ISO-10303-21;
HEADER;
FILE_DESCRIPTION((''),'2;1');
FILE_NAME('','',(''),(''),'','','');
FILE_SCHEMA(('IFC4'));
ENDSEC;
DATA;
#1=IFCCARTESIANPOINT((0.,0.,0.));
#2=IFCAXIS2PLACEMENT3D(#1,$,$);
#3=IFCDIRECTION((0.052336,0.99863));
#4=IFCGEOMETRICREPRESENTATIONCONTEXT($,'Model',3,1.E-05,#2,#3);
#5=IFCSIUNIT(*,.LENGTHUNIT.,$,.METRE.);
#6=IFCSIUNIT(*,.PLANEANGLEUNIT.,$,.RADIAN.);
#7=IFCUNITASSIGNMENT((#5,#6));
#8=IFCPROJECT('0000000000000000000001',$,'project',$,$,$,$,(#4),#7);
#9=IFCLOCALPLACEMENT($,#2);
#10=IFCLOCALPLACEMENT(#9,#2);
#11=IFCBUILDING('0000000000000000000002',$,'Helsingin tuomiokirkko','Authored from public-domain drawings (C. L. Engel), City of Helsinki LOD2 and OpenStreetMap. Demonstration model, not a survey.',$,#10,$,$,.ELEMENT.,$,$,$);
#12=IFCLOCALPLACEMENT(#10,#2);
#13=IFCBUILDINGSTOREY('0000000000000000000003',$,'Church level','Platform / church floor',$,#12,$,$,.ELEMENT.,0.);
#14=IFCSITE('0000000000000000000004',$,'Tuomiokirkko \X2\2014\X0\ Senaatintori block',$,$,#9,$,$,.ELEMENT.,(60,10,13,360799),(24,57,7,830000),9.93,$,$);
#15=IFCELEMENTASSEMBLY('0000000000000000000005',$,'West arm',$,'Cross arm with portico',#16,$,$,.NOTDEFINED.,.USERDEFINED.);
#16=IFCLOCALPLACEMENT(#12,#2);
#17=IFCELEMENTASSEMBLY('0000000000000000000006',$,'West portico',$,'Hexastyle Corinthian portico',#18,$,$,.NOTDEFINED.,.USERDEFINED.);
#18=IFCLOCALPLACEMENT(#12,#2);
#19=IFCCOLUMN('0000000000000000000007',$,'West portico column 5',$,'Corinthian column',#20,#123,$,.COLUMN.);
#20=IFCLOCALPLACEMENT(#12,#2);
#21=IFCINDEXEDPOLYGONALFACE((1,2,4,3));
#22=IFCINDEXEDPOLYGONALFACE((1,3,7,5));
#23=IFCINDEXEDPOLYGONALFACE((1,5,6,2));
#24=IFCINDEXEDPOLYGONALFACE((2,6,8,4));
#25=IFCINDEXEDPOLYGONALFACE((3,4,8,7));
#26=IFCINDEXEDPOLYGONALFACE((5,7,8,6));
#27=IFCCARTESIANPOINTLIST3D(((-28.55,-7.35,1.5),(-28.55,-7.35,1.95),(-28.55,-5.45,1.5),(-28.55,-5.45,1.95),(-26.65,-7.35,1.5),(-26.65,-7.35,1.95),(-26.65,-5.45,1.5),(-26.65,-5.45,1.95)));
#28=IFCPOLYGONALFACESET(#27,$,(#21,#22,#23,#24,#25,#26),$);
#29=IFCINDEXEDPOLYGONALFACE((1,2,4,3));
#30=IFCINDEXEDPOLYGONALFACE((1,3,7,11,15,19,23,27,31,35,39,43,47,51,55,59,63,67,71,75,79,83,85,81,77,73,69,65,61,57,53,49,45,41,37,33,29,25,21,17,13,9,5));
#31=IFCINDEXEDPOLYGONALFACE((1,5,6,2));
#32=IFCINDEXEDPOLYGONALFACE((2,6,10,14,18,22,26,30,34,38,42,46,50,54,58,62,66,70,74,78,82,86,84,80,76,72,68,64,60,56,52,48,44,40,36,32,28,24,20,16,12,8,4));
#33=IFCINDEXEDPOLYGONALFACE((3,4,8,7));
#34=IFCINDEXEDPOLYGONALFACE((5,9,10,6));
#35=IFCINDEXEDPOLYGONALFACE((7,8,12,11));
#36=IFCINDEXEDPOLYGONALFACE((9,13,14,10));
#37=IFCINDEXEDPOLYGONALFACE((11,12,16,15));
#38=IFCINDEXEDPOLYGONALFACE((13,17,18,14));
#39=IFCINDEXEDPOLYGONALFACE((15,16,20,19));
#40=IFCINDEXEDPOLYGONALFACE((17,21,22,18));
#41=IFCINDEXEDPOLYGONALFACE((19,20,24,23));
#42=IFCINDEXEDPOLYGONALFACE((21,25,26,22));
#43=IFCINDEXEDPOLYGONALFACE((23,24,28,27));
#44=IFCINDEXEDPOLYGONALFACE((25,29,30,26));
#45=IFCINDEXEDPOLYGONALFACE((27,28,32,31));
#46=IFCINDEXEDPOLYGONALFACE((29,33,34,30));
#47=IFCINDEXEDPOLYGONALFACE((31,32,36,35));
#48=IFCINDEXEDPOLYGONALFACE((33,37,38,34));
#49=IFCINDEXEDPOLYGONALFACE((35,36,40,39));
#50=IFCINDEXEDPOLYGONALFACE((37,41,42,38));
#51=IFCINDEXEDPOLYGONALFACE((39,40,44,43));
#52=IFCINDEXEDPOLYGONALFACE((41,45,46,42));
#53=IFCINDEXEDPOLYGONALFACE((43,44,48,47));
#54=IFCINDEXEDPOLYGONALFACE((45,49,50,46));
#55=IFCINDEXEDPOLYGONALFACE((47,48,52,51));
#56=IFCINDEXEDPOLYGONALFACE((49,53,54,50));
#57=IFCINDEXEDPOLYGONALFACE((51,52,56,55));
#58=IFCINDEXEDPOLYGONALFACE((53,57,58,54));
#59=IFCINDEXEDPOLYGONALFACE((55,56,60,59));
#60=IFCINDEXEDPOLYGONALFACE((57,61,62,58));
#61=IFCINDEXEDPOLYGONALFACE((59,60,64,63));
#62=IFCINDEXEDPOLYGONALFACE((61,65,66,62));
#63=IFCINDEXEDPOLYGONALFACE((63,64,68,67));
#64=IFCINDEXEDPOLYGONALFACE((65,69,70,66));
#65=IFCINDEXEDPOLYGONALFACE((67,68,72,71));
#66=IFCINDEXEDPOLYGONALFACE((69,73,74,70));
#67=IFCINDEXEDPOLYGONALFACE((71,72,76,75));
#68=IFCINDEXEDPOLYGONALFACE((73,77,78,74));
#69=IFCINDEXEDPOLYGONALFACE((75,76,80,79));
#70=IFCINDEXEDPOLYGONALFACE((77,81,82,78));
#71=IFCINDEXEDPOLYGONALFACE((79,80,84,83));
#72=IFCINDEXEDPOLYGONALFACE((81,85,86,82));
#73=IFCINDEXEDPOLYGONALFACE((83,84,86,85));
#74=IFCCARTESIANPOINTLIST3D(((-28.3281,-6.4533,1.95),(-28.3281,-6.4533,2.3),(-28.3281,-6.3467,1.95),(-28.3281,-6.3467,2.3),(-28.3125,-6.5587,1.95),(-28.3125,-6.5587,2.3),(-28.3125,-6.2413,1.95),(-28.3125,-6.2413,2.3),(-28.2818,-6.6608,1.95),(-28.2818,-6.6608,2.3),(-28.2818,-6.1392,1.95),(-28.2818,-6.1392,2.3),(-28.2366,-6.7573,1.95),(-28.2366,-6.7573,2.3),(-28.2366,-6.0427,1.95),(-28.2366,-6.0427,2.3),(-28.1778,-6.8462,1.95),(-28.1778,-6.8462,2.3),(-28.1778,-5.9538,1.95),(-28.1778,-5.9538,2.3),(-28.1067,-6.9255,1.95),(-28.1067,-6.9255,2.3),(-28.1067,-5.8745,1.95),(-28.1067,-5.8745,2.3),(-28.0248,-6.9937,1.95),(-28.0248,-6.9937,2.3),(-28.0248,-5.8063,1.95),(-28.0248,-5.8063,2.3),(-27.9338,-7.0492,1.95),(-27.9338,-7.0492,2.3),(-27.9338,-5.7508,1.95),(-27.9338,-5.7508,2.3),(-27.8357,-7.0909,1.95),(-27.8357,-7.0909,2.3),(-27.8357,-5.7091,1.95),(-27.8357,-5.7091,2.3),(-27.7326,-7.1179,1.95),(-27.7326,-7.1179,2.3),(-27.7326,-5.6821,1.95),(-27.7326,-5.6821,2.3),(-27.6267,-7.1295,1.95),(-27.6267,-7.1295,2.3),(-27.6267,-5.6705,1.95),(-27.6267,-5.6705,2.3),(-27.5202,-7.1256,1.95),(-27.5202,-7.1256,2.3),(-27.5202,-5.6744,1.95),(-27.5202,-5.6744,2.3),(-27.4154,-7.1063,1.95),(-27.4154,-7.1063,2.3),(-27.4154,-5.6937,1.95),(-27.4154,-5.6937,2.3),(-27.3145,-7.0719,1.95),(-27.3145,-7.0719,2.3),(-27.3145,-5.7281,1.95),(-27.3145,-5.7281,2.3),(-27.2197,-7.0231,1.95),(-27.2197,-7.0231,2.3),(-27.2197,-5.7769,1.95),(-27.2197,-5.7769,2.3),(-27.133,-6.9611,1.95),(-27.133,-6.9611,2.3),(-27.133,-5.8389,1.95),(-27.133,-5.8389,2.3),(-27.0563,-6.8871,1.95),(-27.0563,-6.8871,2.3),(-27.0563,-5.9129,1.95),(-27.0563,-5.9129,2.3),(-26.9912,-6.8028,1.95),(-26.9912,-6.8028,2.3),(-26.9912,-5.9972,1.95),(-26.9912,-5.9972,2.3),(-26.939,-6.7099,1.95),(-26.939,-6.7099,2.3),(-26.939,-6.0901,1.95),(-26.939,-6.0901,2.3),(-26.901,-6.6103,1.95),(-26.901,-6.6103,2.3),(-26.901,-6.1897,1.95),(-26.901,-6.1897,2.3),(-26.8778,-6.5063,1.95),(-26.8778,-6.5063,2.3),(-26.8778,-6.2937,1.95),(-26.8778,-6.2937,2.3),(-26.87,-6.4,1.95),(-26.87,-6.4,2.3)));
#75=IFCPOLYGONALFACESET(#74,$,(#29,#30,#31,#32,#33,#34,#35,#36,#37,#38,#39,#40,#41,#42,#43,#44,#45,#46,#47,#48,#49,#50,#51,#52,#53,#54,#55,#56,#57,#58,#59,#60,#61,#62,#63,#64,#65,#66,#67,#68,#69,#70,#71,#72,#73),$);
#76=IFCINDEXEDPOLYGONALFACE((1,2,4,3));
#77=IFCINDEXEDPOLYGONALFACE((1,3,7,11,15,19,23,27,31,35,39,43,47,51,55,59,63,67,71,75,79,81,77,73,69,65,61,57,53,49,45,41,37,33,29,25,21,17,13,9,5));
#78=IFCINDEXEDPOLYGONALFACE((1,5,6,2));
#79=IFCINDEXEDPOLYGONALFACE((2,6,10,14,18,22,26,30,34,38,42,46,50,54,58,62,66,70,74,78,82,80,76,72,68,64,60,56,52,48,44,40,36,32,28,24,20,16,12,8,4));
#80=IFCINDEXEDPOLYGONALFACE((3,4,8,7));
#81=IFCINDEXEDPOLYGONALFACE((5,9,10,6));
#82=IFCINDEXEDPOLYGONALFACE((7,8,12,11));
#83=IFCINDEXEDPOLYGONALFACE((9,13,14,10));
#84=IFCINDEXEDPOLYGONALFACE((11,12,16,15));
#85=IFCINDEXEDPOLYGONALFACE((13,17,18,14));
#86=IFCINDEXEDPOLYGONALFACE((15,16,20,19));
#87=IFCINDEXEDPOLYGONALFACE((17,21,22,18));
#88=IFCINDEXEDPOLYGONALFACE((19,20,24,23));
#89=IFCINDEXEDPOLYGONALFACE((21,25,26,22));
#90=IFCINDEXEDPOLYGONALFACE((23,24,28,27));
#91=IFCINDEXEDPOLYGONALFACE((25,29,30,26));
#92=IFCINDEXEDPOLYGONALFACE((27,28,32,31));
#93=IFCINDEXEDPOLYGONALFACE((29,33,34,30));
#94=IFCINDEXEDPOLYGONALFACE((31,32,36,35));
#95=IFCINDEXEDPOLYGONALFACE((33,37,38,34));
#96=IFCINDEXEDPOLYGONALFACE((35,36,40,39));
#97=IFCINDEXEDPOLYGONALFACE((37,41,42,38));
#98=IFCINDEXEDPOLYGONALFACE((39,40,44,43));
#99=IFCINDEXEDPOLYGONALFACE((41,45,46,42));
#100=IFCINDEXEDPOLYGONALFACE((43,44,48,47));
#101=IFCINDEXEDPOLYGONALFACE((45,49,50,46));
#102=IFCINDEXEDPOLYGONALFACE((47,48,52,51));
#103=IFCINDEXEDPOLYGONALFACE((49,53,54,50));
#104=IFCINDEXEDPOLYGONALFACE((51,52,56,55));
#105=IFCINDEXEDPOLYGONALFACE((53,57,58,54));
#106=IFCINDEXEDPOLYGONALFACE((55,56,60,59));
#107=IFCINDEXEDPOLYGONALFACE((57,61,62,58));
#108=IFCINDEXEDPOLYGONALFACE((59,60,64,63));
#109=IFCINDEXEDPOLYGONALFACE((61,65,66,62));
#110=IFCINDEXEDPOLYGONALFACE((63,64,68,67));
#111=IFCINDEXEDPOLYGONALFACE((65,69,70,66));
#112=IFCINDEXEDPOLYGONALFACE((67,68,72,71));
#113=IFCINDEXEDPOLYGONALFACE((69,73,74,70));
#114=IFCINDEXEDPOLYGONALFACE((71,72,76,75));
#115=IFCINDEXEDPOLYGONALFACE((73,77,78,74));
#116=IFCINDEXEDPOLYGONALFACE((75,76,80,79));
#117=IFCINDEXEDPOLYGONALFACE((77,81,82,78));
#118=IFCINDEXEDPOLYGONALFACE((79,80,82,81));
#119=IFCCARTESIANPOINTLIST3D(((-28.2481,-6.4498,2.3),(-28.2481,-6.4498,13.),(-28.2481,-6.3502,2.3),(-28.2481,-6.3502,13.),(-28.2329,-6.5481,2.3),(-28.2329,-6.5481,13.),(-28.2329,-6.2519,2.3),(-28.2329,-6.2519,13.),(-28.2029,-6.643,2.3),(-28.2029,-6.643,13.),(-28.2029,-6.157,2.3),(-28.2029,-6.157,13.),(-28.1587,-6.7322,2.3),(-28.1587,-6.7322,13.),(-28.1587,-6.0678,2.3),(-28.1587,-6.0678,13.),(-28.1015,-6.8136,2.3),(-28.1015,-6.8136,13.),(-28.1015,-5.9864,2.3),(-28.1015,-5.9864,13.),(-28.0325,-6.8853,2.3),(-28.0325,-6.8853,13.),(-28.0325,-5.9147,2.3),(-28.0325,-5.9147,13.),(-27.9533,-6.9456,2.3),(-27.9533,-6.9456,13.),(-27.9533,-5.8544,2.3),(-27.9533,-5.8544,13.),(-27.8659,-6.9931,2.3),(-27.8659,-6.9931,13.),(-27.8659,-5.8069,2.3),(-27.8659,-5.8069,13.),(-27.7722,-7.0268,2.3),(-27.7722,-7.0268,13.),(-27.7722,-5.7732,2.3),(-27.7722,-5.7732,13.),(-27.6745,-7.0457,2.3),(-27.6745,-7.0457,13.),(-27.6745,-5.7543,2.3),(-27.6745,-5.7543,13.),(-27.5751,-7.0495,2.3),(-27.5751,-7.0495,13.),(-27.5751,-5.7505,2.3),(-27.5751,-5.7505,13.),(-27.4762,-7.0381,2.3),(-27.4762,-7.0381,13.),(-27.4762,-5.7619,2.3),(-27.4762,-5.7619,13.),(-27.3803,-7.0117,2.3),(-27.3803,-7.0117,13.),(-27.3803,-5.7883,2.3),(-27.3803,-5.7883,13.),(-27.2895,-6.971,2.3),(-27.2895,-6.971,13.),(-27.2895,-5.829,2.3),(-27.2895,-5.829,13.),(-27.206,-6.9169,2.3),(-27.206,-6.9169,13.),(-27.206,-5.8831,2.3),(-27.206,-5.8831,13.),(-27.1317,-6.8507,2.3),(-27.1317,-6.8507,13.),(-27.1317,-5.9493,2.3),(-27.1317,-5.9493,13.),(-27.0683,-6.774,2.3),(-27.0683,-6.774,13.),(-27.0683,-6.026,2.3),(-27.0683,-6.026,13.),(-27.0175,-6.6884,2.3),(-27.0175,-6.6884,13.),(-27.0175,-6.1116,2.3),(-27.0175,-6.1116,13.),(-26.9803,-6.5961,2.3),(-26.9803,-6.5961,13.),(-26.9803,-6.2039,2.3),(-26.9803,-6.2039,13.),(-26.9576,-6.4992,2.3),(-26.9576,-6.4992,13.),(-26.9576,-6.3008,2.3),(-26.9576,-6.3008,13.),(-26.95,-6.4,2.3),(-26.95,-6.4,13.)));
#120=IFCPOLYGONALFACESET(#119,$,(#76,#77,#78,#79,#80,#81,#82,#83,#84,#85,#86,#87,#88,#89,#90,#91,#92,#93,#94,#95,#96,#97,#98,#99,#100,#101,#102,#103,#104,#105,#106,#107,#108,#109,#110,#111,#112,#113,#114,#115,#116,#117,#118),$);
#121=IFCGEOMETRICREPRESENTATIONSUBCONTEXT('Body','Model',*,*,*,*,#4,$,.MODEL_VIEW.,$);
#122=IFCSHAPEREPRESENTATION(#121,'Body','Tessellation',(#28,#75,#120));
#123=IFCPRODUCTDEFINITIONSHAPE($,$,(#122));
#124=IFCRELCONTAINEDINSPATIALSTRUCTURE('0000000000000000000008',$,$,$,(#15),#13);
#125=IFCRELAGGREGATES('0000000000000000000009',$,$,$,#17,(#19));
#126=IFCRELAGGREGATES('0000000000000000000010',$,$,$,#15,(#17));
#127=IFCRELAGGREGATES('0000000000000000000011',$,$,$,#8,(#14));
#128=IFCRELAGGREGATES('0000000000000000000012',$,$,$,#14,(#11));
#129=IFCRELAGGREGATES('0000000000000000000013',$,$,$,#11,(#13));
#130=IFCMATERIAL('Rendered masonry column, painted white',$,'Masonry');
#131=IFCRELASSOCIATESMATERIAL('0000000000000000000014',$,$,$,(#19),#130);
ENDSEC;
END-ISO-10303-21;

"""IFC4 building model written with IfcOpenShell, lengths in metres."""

from ifc_helpers import new_model, si_unit, direction, frame, origin, origin_2d_with_axis, place, context, subcontext, project, spatial, rectangle, circle, extrude, material, element, aggregate, save


model = new_model("IFC4")

# Units and contexts
model_context = context("Model", 3, precision=1e-05, world=origin(), true_north=direction((0.052336, 0.99863)))
body_context = subcontext(model_context, "Body", "Model", "MODEL_VIEW")
ifc_project = project(units=[si_unit("LENGTHUNIT", "METRE"), si_unit("PLANEANGLEUNIT", "RADIAN")], contexts=[model_context])

# Site, building, storey
site_placement = place(None, origin())
site = spatial("IfcSite", under=ifc_project, at=site_placement, Name="Tuomiokirkko — Senaatintori block", CompositionType="ELEMENT", RefLatitude=(60, 10, 13, 360799), RefLongitude=(24, 57, 7, 830000), RefElevation=9.93)
building_placement = place(site_placement, origin())
building = spatial("IfcBuilding", under=site, at=building_placement, Name="Helsingin tuomiokirkko", Description="Authored from public-domain drawings (C. L. Engel), City of Helsinki LOD2 and OpenStreetMap. Demonstration model, not a survey.", CompositionType="ELEMENT")
storey_placement = place(building_placement, origin())
storey = spatial("IfcBuildingStorey", under=building, at=storey_placement, Name="Church level", Description="Platform / church floor", CompositionType="ELEMENT", Elevation=0.0)

# Element assemblies, column
assembly_1_placement = place(building_placement, origin())
assembly_1 = element("IfcElementAssembly", 1, at=assembly_1_placement, inside=storey, Name="West arm", ObjectType="Cross arm with portico", AssemblyPlace="NOTDEFINED", PredefinedType="USERDEFINED")
assembly_2_placement = place(building_placement, origin())
assembly_2 = element("IfcElementAssembly", 2, at=assembly_2_placement, Name="West portico", ObjectType="Hexastyle Corinthian portico", AssemblyPlace="NOTDEFINED", PredefinedType="USERDEFINED")
ifc_material_1 = material(Name="Rendered masonry column, painted white", Category="Masonry")
column_1_placement = place(building_placement, origin())
column_1 = element("IfcColumn", 3, at=column_1_placement, material=ifc_material_1, Name="West portico column 5", ObjectType="Corinthian column", PredefinedType="COLUMN", context=body_context, shape_type="SweptSolid", body=[
    extrude(rectangle(XDim=1.9, YDim=1.9, at=origin_2d_with_axis()), frame((-27.6, -6.4, 1.5)), (0.0, 0.0, 1.0), 0.45),
    extrude(circle(Radius=0.73, at=origin_2d_with_axis()), frame((-27.6, -6.4, 1.95)), (0.0, 0.0, 1.0), 0.35),
    extrude(circle(Radius=0.65, at=origin_2d_with_axis()), frame((-27.6, -6.4, 2.3)), (0.0, 0.0, 1.0), 10.7),
])

aggregate(assembly_2, [column_1])

aggregate(assembly_1, [assembly_2])

save(model, "model.ifc")
